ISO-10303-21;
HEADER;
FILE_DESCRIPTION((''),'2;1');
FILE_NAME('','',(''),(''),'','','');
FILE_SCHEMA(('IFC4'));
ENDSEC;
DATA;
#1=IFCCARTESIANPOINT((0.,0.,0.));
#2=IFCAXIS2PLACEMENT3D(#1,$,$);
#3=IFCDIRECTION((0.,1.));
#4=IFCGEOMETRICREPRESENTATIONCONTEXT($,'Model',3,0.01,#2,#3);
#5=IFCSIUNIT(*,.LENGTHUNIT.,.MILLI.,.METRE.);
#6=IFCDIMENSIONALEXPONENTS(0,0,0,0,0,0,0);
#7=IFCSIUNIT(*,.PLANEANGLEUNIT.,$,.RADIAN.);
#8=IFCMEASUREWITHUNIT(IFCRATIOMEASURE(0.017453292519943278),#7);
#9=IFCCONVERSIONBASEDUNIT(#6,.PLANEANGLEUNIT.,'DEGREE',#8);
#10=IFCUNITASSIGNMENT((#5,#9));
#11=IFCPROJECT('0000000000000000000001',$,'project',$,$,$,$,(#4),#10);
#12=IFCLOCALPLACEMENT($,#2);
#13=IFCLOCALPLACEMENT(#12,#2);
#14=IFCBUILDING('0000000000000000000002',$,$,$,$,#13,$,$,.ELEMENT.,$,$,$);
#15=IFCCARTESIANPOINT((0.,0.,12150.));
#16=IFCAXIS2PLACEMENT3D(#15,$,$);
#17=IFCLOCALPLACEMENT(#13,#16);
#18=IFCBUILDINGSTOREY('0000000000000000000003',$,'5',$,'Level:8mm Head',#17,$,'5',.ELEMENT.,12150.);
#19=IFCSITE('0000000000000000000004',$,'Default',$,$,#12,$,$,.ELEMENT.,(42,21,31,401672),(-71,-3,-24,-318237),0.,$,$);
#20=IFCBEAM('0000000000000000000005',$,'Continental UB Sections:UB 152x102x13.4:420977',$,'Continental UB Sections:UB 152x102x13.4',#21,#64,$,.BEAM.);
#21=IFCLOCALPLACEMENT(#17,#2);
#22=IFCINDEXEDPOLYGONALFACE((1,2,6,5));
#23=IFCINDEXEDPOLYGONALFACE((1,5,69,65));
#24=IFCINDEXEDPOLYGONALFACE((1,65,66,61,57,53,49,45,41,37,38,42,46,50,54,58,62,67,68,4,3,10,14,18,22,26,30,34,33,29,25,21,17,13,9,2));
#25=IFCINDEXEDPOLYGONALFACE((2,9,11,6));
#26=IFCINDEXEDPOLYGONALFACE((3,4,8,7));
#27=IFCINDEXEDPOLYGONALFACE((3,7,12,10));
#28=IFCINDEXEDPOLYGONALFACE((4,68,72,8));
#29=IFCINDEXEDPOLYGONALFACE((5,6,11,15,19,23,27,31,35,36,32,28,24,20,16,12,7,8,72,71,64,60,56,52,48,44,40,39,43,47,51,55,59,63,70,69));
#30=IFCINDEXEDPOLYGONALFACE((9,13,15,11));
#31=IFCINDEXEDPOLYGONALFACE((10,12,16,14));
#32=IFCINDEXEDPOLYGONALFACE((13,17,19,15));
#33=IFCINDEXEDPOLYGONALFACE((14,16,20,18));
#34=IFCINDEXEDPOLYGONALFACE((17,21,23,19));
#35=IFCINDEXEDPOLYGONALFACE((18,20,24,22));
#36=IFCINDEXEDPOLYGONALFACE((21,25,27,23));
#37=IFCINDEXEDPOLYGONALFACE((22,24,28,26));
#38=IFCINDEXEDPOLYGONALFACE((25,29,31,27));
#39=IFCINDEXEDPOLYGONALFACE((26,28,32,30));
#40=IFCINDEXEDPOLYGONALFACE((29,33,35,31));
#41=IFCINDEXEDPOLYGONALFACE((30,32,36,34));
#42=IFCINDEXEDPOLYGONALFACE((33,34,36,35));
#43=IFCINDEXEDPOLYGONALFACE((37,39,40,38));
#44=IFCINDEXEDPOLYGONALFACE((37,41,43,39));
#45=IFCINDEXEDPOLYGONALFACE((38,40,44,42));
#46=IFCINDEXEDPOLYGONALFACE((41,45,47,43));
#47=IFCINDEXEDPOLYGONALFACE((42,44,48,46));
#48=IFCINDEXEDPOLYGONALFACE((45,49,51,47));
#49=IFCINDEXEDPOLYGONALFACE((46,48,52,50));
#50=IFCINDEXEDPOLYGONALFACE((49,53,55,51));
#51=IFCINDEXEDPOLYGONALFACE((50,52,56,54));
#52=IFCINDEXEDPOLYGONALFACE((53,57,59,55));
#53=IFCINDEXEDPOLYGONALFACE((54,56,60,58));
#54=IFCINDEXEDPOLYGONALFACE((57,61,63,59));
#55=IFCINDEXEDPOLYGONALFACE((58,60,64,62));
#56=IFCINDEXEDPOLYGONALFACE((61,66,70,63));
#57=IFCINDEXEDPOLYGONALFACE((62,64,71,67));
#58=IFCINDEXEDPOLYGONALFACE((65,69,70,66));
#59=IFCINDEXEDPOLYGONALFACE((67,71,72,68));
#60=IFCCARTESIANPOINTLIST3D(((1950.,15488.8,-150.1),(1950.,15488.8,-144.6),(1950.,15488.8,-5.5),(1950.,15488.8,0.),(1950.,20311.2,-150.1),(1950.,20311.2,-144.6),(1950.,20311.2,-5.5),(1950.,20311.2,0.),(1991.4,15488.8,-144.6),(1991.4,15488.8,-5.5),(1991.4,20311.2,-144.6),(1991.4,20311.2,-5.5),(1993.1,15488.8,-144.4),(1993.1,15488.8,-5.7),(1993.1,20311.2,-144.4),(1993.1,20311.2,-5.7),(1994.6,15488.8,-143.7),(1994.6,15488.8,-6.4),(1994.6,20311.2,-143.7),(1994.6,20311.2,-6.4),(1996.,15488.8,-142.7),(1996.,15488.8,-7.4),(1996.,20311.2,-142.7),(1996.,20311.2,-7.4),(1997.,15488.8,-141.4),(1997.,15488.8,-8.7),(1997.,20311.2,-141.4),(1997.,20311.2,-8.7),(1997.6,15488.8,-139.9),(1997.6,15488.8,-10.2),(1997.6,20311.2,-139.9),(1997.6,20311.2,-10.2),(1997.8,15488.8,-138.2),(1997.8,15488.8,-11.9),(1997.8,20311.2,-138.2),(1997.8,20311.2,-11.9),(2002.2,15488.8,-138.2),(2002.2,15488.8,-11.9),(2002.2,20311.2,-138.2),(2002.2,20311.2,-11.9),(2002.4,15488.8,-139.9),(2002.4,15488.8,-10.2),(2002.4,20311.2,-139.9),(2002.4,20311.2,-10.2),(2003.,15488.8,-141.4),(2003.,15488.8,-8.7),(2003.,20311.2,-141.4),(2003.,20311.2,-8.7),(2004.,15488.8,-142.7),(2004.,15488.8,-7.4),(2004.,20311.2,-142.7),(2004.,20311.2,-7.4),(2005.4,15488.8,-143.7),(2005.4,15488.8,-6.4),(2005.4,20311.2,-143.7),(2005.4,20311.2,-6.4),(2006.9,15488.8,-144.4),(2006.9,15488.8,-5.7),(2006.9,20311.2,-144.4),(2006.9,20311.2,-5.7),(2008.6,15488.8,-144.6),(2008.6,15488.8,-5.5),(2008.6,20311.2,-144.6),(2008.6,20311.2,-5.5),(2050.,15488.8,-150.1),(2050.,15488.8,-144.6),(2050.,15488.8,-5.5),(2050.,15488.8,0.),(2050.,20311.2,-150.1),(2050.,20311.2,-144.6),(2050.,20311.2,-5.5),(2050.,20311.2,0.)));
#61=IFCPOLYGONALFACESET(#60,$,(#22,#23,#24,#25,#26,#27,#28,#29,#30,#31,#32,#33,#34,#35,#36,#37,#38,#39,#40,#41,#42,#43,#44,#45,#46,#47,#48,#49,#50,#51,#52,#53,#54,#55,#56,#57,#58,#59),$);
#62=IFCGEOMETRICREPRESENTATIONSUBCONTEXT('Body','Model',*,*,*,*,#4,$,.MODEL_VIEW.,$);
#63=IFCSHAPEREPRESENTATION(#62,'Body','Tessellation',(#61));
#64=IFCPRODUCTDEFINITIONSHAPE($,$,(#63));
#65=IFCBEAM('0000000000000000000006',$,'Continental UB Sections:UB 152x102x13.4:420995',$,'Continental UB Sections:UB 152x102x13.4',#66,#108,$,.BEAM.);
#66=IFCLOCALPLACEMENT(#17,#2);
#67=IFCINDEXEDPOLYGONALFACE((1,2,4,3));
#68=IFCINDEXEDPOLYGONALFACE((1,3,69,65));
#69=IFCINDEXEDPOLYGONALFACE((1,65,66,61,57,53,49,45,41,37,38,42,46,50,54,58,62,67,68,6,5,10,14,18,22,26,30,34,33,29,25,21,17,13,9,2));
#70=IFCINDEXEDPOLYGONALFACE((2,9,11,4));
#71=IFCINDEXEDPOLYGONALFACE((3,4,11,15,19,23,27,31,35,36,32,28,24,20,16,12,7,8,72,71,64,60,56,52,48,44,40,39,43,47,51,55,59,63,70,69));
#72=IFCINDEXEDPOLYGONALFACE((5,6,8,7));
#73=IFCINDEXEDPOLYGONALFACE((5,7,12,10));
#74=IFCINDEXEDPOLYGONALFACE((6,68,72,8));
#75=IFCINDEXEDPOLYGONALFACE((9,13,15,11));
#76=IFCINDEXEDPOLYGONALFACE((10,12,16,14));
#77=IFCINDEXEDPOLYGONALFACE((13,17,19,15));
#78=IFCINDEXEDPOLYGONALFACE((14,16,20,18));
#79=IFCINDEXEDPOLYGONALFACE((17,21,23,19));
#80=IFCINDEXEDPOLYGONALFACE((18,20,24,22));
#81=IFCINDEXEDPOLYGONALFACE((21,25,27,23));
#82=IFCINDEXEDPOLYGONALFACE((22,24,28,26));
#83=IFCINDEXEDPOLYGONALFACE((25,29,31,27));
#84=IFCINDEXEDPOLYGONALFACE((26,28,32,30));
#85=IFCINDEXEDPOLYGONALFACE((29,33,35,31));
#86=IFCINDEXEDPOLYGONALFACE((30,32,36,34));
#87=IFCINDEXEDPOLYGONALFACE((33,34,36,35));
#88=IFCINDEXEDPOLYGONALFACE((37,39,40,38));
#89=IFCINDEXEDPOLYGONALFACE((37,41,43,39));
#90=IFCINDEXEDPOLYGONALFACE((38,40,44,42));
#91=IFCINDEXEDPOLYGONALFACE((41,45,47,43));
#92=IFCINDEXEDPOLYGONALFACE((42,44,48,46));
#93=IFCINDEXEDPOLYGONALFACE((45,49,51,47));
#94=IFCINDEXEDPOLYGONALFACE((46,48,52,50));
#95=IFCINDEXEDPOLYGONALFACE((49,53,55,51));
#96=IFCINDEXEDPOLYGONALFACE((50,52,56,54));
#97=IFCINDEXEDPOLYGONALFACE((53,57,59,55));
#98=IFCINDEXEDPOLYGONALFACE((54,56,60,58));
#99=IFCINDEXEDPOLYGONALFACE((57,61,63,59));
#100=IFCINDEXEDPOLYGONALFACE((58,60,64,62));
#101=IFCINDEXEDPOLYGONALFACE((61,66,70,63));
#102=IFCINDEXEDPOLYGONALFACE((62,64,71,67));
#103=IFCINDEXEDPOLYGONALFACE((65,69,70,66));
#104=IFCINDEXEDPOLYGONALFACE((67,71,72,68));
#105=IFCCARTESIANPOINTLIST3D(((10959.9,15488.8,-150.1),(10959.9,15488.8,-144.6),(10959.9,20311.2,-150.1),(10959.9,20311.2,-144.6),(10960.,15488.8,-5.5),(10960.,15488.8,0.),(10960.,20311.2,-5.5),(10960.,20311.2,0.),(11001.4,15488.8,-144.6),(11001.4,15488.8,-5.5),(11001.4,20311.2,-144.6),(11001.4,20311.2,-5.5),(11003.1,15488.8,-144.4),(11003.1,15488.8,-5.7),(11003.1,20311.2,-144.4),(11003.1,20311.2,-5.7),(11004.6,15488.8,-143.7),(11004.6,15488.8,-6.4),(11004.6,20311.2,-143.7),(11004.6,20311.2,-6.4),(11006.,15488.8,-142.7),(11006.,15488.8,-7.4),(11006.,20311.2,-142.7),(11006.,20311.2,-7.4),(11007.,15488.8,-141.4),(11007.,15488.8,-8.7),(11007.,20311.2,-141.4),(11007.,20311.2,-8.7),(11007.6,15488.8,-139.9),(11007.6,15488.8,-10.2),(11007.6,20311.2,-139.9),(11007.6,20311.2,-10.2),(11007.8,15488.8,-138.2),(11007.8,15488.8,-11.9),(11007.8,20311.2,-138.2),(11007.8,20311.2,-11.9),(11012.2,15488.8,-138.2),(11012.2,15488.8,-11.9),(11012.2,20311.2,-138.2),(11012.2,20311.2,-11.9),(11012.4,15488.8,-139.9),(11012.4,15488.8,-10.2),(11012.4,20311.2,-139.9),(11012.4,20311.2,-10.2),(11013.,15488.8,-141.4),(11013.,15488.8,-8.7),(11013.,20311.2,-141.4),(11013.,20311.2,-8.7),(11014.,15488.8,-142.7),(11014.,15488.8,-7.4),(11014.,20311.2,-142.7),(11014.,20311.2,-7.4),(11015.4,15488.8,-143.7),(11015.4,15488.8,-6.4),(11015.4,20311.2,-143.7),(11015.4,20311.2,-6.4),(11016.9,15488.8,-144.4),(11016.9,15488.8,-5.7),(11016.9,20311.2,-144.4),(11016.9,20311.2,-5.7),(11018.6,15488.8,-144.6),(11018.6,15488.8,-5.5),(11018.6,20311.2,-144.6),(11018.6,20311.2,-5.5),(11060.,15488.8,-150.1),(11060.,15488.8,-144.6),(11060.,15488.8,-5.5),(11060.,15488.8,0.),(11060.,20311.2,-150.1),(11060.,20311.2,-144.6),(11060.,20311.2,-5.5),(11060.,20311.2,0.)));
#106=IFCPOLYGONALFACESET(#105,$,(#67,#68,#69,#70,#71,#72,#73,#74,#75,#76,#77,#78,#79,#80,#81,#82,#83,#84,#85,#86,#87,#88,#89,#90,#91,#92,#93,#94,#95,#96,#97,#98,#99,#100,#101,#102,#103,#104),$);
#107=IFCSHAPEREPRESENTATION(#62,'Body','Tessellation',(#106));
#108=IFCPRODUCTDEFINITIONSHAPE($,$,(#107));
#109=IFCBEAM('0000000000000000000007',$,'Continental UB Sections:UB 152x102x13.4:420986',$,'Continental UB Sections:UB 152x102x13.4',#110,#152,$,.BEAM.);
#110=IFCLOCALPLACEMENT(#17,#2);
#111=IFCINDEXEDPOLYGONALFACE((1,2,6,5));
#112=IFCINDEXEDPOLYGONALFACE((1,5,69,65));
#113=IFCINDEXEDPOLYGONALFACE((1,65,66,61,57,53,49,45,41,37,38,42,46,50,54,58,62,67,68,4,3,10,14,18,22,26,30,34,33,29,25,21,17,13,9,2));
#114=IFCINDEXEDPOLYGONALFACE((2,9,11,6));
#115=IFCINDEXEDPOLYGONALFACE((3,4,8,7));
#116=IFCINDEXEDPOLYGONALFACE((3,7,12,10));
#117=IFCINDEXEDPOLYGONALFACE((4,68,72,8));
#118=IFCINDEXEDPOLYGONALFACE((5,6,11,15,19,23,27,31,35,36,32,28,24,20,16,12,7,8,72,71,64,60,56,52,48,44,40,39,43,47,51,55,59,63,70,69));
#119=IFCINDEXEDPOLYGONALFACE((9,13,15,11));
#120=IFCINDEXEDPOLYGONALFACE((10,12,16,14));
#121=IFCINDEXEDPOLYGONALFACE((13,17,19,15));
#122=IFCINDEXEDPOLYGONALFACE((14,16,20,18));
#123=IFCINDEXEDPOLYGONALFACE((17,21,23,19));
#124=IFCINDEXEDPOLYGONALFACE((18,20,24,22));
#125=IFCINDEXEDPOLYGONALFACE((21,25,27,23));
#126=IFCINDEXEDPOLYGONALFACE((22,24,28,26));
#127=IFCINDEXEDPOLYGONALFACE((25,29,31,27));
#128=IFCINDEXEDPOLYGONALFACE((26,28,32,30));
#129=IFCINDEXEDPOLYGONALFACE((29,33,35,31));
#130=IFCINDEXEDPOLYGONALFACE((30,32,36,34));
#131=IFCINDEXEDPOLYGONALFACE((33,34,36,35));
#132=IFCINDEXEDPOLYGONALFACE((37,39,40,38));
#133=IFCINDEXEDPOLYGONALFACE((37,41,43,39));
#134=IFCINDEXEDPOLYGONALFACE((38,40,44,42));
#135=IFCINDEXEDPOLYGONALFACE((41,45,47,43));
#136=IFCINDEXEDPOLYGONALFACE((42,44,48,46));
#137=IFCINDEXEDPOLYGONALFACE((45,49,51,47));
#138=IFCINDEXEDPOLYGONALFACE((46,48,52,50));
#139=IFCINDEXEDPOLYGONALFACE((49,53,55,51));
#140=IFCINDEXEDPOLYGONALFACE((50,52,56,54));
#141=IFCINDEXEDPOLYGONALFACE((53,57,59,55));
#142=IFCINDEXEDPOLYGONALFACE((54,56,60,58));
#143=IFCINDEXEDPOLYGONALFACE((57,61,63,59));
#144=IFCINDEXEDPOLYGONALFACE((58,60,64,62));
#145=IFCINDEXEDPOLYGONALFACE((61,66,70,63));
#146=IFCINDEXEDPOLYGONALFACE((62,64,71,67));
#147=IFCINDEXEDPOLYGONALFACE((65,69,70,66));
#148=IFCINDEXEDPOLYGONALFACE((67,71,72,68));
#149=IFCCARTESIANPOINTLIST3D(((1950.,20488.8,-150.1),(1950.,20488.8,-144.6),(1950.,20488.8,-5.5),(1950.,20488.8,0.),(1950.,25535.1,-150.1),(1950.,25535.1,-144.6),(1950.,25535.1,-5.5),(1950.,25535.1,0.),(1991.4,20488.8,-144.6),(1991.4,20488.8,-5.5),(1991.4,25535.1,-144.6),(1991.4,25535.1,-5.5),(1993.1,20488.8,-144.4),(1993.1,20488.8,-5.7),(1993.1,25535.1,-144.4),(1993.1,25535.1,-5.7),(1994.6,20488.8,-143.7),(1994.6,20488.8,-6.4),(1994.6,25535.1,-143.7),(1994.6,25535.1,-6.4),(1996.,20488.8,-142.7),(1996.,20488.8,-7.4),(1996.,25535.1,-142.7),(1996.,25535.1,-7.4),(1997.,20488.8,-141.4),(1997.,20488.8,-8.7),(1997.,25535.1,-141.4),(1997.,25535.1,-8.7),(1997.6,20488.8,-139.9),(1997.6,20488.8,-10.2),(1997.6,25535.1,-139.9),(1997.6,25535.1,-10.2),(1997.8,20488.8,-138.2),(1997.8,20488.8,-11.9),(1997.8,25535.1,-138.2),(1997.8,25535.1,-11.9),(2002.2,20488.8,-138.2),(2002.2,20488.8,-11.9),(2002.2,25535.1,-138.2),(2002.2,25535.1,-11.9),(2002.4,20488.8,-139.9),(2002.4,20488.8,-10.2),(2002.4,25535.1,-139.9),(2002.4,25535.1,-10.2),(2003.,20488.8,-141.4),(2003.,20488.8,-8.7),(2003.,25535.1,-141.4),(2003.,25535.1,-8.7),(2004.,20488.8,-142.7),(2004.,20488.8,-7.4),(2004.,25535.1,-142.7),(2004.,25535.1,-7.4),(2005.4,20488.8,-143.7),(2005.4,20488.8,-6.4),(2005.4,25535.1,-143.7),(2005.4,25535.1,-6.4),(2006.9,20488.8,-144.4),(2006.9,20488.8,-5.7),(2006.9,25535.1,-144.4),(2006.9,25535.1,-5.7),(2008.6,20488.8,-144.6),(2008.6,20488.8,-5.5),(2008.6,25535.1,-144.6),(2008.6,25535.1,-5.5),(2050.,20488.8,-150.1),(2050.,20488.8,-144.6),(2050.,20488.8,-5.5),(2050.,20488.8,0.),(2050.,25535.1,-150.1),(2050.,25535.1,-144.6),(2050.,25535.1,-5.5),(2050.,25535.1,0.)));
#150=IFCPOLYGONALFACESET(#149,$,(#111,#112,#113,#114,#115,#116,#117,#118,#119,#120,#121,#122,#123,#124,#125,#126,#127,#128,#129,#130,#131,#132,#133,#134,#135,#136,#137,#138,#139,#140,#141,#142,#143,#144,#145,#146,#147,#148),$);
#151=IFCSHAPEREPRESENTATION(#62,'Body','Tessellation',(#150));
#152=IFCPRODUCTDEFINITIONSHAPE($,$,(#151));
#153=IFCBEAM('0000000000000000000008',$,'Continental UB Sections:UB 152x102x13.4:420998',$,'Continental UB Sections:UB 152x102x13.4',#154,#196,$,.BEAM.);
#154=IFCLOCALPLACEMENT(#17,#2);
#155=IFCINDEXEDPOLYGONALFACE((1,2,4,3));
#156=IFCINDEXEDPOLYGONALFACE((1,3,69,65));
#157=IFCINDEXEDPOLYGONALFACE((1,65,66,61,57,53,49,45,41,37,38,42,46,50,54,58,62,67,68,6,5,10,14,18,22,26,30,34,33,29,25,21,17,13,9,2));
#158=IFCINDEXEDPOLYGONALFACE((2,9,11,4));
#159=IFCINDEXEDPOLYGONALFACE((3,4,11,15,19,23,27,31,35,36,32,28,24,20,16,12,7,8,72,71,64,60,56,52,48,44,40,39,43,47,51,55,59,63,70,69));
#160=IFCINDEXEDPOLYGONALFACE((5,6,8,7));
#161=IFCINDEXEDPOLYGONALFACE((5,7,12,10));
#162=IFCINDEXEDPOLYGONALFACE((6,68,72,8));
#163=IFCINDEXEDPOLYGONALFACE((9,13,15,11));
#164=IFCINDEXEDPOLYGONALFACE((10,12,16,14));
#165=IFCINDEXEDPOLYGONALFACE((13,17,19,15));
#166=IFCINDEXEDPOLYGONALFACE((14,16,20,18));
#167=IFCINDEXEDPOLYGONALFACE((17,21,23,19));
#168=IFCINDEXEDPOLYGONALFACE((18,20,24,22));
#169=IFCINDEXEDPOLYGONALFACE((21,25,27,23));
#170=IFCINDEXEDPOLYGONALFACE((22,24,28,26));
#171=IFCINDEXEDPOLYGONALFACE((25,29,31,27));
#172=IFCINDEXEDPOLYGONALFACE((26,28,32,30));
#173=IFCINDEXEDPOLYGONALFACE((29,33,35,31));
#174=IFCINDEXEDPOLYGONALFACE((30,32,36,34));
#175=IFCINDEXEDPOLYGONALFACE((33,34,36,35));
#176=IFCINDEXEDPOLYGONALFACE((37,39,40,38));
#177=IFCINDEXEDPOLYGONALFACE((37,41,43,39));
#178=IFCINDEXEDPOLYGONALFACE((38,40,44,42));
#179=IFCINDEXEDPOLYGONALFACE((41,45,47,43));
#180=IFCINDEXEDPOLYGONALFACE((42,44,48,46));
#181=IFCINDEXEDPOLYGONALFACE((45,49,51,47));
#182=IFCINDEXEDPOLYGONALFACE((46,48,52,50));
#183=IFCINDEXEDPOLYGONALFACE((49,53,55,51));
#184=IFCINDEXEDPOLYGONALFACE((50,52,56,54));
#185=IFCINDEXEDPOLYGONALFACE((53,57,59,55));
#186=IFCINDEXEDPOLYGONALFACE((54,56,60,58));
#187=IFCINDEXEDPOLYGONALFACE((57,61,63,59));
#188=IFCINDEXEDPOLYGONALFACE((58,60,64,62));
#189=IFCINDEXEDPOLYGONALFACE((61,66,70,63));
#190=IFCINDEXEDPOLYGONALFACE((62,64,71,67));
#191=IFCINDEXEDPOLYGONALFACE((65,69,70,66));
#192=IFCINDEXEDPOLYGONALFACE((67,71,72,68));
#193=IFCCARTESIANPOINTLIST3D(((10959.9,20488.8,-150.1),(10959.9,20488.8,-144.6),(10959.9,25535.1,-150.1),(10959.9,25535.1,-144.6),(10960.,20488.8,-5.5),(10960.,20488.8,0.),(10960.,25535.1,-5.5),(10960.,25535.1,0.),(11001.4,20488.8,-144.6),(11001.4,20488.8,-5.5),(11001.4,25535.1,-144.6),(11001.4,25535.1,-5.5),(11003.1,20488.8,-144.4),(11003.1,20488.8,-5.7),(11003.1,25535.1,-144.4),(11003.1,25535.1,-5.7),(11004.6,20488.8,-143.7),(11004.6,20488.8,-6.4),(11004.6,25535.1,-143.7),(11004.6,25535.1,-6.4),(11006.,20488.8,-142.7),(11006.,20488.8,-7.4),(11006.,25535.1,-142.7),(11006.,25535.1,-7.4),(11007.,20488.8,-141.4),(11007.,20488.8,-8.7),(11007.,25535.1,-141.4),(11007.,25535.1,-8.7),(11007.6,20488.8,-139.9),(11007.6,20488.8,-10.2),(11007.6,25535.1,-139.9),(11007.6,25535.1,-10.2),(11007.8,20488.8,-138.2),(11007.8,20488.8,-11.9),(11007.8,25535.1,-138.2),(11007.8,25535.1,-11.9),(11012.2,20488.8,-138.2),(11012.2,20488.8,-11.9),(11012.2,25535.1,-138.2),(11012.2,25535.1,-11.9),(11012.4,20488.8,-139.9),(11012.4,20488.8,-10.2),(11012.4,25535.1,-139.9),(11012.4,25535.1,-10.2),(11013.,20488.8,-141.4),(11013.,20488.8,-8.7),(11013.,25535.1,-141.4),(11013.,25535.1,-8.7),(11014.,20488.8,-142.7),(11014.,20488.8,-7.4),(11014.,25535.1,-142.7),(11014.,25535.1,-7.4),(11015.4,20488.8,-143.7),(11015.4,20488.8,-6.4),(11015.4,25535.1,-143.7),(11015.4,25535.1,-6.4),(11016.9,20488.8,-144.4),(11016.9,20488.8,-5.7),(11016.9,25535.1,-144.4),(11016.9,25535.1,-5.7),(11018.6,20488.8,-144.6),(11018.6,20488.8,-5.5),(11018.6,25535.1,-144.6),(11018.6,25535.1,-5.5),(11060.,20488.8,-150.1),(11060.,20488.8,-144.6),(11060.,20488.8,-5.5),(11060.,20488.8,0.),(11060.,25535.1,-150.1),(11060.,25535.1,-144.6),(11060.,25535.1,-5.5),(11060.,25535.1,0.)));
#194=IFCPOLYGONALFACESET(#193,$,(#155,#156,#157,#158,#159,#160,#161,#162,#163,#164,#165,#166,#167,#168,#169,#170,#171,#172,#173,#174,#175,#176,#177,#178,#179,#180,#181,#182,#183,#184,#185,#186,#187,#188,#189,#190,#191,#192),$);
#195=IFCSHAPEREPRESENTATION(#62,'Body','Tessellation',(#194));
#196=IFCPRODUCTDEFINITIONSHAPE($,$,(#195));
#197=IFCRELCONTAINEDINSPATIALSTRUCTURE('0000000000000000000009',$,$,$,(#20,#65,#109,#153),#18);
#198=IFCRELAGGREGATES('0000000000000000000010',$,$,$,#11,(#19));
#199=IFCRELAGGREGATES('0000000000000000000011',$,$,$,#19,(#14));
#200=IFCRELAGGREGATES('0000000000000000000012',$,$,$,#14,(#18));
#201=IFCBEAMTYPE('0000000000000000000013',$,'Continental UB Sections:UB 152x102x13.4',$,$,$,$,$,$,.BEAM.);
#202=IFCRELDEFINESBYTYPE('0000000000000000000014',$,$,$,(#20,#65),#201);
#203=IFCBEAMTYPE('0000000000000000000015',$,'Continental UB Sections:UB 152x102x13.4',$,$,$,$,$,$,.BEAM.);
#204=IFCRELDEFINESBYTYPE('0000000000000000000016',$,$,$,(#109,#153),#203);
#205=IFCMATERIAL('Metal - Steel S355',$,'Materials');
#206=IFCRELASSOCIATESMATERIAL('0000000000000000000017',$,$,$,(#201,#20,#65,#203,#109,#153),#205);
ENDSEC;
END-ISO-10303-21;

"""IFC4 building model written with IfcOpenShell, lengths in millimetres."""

from ifc_helpers import new_model, entity, si_unit, converted_unit, direction, frame, origin, place, context, subcontext, project, spatial, line, arc, indexed_curve, outline, extrude, source, transform, mapped, material, type_object, type_shapes, element, save


model = new_model("IFC4")

# Units and contexts
model_context = context("Model", 3, precision=0.01, world=origin(), true_north=direction((0.0, 1.0)))
body_context = subcontext(model_context, "Body", "Model", "MODEL_VIEW")
ifc_project = project(units=[si_unit("LENGTHUNIT", "METRE", prefix="MILLI"), converted_unit("PLANEANGLEUNIT", "DEGREE", entity("IfcRatioMeasure", 0.017453292519943278), si_unit("PLANEANGLEUNIT", "RADIAN"), dimensions=[0, 0, 0, 0, 0, 0, 0])], contexts=[model_context])

# Site, building, storey
site_placement = place(None, origin())
site = spatial("IfcSite", under=ifc_project, at=site_placement, Name="Default", CompositionType="ELEMENT", RefLatitude=(42, 21, 31, 401672), RefLongitude=(-71, -3, -24, -318237), RefElevation=0.0)
building_placement = place(site_placement, origin())
building = spatial("IfcBuilding", under=site, at=building_placement, CompositionType="ELEMENT")
storey_placement = place(building_placement, frame((0.0, 0.0, 12150.0)))
storey = spatial("IfcBuildingStorey", under=building, at=storey_placement, Name="5", ObjectType="Level:8mm Head", LongName="5", CompositionType="ELEMENT", Elevation=12150.0)

# Beams
ifc_material = material(Name="Metal - Steel S355", Category="Materials")
beam_type_1 = type_object("IfcBeamType", Name="Continental UB Sections:UB 152x102x13.4", PredefinedType="BEAM", material=ifc_material)
shared_shape_1 = source(origin(), body_context, "Body", "SweptSolid", [
    extrude(outline(indexed_curve([(-75.0, -50.1), (-69.6, -50.1), (-69.6, -8.5), (-67.7, -4.0), (-63.2, -2.1), (63.1, -2.1), (67.7, -4.0), (69.5, -8.5), (69.5, -50.1), (75.1, -50.1), (75.1, 50.1), (69.5, 50.1), (69.5, 8.6), (67.7, 4.0), (63.1, 2.2), (-63.2, 2.2), (-67.7, 4.0), (-69.6, 8.6), (-69.6, 50.0), (-75.0, 50.0)], segments=[line(1, 2, 3), arc(3, 4, 5), line(5, 6), arc(6, 7, 8), line(8, 9, 10, 11, 12, 13), arc(13, 14, 15), line(15, 16), arc(16, 17, 18), line(18, 19, 20, 1)], self_intersect=False)), frame((-2411.2, 0.0, 0.0), z_axis=(1.0, 0.0, 0.0), x_axis=(0.0, 0.0, -1.0)), (0.0, 0.0, 1.0), 4822.4),
])
type_shapes(beam_type_1, [shared_shape_1])
for number, where, z_axis, x_axis, name in (
    (1, (2000.0, 17900.0, -75.1), (0.0, 0.0, 1.0), (0.0, 1.0, 0.0), "Continental UB Sections:UB 152x102x13.4:420977"),
    (2, (11010.0, 17900.0, -75.1), (0.0, 0.0, 1.0), (0.0, 1.0, 0.0), "Continental UB Sections:UB 152x102x13.4:420995"),
):
    element("IfcBeam", number, at=place(storey_placement, frame(where, z_axis=z_axis, x_axis=x_axis)), inside=storey, type_object=beam_type_1, material=ifc_material, Name=name, ObjectType="Continental UB Sections:UB 152x102x13.4", PredefinedType="BEAM", context=body_context, shape_type="MappedRepresentation", body=[
        mapped(shared_shape_1, transform((0.0, 0.0, 0.0), scale=1.0)),
    ])
beam_type_2 = type_object("IfcBeamType", Name="Continental UB Sections:UB 152x102x13.4", PredefinedType="BEAM", material=ifc_material)
shared_shape_2 = source(origin(), body_context, "Body", "SweptSolid", [
    extrude(outline(indexed_curve([(-75.0, -50.1), (-69.6, -50.1), (-69.6, -8.5), (-67.7, -4.0), (-63.2, -2.1), (63.1, -2.1), (67.7, -4.0), (69.5, -8.5), (69.5, -50.1), (75.1, -50.1), (75.1, 50.1), (69.5, 50.1), (69.5, 8.6), (67.7, 4.0), (63.1, 2.2), (-63.2, 2.2), (-67.7, 4.0), (-69.6, 8.6), (-69.6, 50.0), (-75.0, 50.0)], segments=[line(1, 2, 3), arc(3, 4, 5), line(5, 6), arc(6, 7, 8), line(8, 9, 10, 11, 12, 13), arc(13, 14, 15), line(15, 16), arc(16, 17, 18), line(18, 19, 20, 1)], self_intersect=False)), frame((-2561.2, 0.0, 0.0), z_axis=(1.0, 0.0, 0.0), x_axis=(0.0, 0.0, -1.0)), (0.0, 0.0, 1.0), 5046.3),
])
type_shapes(beam_type_2, [shared_shape_2])
for number, where, z_axis, x_axis, name in (
    (3, (2000.0, 23050.0, -75.1), (0.0, 0.0, 1.0), (0.0, 1.0, 0.0), "Continental UB Sections:UB 152x102x13.4:420986"),
    (4, (11010.0, 23050.0, -75.1), (0.0, 0.0, 1.0), (0.0, 1.0, 0.0), "Continental UB Sections:UB 152x102x13.4:420998"),
):
    element("IfcBeam", number, at=place(storey_placement, frame(where, z_axis=z_axis, x_axis=x_axis)), inside=storey, type_object=beam_type_2, material=ifc_material, Name=name, ObjectType="Continental UB Sections:UB 152x102x13.4", PredefinedType="BEAM", context=body_context, shape_type="MappedRepresentation", body=[
        mapped(shared_shape_2, transform((0.0, 0.0, 0.0), scale=1.0)),
    ])

save(model, "model.ifc")
